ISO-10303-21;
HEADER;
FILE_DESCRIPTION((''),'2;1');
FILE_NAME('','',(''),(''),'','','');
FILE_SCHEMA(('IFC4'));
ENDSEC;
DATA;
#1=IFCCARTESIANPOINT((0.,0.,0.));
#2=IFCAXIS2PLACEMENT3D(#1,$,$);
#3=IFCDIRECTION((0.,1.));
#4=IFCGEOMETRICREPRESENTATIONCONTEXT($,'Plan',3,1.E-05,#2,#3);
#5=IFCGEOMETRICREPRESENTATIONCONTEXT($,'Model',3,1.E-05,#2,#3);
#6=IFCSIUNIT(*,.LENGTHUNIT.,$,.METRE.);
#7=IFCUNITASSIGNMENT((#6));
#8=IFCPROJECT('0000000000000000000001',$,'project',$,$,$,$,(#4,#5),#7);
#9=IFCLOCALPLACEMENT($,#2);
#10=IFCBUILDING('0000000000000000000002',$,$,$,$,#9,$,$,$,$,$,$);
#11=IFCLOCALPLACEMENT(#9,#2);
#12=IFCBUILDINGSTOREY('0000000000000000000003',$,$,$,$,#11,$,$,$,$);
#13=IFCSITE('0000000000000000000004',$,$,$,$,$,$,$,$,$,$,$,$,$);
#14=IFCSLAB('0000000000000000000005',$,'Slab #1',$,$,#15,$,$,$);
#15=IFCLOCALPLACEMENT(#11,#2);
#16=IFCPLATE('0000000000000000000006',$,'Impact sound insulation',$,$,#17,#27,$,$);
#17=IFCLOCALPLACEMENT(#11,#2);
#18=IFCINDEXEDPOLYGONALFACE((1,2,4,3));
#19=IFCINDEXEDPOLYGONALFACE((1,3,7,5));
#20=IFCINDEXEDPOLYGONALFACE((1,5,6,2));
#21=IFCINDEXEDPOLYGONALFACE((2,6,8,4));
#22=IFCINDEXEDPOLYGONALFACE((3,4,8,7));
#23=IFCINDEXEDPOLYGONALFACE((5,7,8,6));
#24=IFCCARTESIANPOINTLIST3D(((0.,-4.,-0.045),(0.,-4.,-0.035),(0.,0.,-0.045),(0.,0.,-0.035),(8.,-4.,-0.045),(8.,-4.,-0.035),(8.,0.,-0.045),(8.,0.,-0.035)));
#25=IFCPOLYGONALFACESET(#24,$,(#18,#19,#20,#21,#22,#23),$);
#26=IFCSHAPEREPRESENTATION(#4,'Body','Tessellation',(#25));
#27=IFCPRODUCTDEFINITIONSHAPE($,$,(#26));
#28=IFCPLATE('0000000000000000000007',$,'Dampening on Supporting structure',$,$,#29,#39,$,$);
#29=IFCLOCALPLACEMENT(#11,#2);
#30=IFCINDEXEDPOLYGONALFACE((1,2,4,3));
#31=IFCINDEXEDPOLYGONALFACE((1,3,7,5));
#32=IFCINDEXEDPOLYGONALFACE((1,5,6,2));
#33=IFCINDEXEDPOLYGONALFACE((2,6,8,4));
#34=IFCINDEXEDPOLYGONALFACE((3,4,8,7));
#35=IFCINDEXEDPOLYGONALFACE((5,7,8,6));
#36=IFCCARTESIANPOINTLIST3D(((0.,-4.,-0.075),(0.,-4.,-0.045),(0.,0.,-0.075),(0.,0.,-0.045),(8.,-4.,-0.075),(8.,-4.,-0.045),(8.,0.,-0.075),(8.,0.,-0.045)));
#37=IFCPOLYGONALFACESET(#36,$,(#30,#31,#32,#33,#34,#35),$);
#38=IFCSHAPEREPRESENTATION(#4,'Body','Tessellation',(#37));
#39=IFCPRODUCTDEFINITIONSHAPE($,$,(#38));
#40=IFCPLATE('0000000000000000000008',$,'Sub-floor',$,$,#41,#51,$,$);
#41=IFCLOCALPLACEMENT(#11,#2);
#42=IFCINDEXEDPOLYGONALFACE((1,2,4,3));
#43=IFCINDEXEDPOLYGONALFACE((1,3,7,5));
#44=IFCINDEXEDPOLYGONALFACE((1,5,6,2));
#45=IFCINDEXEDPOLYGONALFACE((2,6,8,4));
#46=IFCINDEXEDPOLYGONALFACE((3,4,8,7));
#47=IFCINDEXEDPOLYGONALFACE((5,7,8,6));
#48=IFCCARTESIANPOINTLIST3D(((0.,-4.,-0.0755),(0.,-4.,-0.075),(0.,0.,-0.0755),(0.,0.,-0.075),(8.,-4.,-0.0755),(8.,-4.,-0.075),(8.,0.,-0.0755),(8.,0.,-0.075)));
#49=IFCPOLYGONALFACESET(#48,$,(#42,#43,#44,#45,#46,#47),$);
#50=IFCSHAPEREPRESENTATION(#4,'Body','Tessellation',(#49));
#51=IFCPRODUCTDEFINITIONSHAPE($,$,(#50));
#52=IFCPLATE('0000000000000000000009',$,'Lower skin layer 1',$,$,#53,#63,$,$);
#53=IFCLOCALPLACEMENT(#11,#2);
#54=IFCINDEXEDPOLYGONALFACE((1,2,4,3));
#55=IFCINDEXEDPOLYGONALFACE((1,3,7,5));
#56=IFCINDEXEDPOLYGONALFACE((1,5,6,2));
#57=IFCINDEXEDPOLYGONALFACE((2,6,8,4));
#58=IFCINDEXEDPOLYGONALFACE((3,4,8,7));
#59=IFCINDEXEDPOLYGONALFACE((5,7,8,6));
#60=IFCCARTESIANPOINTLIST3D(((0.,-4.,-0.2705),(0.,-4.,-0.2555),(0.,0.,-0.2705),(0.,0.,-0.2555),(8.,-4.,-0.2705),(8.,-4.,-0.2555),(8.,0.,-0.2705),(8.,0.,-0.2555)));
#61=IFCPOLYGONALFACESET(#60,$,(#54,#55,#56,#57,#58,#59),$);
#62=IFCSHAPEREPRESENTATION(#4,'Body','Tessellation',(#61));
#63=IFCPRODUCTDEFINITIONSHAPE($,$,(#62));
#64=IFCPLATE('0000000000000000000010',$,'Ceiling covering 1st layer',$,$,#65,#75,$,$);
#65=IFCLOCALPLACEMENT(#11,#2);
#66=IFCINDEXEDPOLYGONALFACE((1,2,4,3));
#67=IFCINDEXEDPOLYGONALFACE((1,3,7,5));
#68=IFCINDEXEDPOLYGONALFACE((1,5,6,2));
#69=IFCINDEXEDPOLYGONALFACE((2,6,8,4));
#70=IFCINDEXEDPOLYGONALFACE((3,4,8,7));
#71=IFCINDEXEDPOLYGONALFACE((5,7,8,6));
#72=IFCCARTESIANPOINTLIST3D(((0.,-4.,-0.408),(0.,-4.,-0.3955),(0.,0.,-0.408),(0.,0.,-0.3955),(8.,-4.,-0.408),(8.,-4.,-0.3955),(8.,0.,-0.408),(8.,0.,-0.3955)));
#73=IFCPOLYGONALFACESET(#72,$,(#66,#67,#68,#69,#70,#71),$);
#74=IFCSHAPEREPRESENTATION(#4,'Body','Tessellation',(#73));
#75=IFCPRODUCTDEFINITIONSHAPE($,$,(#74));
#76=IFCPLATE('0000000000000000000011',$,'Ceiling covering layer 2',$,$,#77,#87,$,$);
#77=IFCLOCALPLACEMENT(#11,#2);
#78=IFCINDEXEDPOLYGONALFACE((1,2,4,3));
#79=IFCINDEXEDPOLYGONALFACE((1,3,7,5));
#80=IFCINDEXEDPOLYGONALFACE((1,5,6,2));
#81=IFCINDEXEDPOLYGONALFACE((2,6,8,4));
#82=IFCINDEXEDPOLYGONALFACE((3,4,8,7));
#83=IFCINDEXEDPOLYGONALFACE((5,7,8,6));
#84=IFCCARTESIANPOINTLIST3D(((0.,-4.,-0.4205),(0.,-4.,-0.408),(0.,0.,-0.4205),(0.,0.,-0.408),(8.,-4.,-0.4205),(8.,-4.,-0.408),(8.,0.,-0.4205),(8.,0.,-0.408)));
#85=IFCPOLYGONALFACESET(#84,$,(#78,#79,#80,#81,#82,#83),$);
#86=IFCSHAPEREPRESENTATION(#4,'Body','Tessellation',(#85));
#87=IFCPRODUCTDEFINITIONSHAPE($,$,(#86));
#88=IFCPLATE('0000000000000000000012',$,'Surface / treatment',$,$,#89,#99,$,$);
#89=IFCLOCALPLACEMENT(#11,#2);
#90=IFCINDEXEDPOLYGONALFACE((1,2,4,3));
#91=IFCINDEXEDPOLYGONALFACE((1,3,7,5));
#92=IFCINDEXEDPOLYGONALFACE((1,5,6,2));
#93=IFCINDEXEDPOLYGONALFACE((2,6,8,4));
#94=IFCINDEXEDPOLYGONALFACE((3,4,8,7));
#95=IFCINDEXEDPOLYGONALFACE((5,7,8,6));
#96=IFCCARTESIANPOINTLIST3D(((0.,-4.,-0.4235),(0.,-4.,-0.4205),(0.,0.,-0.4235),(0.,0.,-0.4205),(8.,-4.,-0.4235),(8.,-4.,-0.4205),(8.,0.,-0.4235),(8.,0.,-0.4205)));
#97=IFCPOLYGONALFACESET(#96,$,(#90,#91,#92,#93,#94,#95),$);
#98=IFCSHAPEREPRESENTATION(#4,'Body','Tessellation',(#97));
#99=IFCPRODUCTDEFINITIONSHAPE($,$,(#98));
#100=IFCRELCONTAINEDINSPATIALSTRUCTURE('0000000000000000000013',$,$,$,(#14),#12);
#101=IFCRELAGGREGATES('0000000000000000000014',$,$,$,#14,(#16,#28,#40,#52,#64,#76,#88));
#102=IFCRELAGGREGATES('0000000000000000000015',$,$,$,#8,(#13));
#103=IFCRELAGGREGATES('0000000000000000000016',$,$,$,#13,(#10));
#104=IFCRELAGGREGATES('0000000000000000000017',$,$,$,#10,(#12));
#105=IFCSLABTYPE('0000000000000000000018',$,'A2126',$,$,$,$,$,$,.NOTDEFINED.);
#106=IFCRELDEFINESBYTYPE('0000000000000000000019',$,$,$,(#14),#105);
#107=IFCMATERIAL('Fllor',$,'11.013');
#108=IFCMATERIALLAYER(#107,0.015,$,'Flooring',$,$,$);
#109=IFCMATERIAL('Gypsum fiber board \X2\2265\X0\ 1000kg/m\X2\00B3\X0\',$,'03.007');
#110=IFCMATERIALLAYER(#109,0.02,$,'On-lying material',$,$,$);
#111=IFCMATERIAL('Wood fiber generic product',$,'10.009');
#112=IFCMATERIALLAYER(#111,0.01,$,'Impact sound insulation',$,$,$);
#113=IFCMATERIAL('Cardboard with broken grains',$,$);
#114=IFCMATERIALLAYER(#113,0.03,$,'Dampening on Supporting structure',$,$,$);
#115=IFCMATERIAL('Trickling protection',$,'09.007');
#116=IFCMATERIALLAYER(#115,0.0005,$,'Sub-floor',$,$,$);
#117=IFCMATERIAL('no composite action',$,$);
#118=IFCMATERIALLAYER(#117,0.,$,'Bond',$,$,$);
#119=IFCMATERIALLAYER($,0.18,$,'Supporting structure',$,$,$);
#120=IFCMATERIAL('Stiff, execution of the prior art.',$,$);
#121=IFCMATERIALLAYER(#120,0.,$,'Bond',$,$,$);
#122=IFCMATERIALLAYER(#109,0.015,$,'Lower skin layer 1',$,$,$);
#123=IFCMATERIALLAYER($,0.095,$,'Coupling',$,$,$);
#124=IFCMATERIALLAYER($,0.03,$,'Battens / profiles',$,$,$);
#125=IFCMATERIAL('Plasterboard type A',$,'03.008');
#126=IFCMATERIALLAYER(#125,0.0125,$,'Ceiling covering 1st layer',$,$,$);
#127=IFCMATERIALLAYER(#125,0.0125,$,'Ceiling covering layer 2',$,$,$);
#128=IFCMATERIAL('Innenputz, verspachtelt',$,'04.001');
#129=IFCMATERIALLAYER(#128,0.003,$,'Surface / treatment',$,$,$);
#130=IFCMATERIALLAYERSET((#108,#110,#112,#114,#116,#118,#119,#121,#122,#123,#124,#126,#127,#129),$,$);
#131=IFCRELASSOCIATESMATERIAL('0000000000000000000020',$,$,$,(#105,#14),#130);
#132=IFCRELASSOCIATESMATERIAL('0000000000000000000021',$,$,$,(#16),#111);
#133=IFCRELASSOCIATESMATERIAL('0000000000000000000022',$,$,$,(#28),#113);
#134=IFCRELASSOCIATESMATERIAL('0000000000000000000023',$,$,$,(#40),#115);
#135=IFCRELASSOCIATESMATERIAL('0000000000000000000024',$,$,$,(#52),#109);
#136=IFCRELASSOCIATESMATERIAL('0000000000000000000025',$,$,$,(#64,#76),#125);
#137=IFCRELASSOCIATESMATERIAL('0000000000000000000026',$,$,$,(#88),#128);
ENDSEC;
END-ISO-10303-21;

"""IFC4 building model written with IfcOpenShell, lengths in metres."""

from ifc_helpers import new_model, si_unit, direction, frame, frame_2d, origin, place, context, project, spatial, rectangle, extrude, material, layer, layer_set, type_object, element, aggregate, save


model = new_model("IFC4")

# Units and contexts
plan_context = context("Plan", 3, precision=1e-05, world=origin(), true_north=direction((0.0, 1.0)))
model_context = context("Model", 3, precision=1e-05, world=origin(), true_north=direction((0.0, 1.0)))
ifc_project = project(units=[si_unit("LENGTHUNIT", "METRE")], contexts=[plan_context, model_context])

# Site, building, storey
site = spatial("IfcSite", under=ifc_project)
building_placement = place(None, origin())
building = spatial("IfcBuilding", under=site, at=building_placement)
storey_placement = place(building_placement, origin())
storey = spatial("IfcBuildingStorey", under=building, at=storey_placement)

# Slab, plates
ifc_material_1 = material(Name="Fllor", Category="11.013")
ifc_layer_1 = layer(ifc_material_1, 0.015, Name="Flooring")
ifc_material_2 = material(Name="Gypsum fiber board ≥ 1000kg/m³", Category="03.007")
ifc_layer_2 = layer(ifc_material_2, 0.02, Name="On-lying material")
ifc_material_3 = material(Name="Wood fiber generic product", Category="10.009")
ifc_layer_3 = layer(ifc_material_3, 0.01, Name="Impact sound insulation")
ifc_material_4 = material(Name="Cardboard with broken grains")
ifc_layer_4 = layer(ifc_material_4, 0.03, Name="Dampening on Supporting structure")
ifc_material_5 = material(Name="Trickling protection", Category="09.007")
ifc_layer_5 = layer(ifc_material_5, 0.0005, Name="Sub-floor")
ifc_material_6 = material(Name="no composite action")
ifc_layer_6 = layer(ifc_material_6, 0.0, Name="Bond")
ifc_layer_7 = layer(None, 0.18, Name="Supporting structure")
ifc_material_7 = material(Name="Stiff, execution of the prior art.")
ifc_layer_8 = layer(ifc_material_7, 0.0, Name="Bond")
ifc_layer_9 = layer(ifc_material_2, 0.015, Name="Lower skin layer 1")
ifc_layer_10 = layer(None, 0.095, Name="Coupling")
ifc_layer_11 = layer(None, 0.03, Name="Battens / profiles")
ifc_material_8 = material(Name="Plasterboard type A", Category="03.008")
ifc_layer_12 = layer(ifc_material_8, 0.0125, Name="Ceiling covering 1st layer")
ifc_layer_13 = layer(ifc_material_8, 0.0125, Name="Ceiling covering layer 2")
ifc_material_9 = material(Name="Innenputz, verspachtelt", Category="04.001")
ifc_layer_14 = layer(ifc_material_9, 0.003, Name="Surface / treatment")
ifc_layer_set = layer_set([ifc_layer_1, ifc_layer_2, ifc_layer_3, ifc_layer_4, ifc_layer_5, ifc_layer_6, ifc_layer_7, ifc_layer_8, ifc_layer_9, ifc_layer_10, ifc_layer_11, ifc_layer_12, ifc_layer_13, ifc_layer_14])
slab_type = type_object("IfcSlabType", Name="A2126", PredefinedType="NOTDEFINED", material=ifc_layer_set)
slab_placement = place(None, frame((0.0, 0.0, 0.0), z_axis=(0.0, 0.0, -1.0), x_axis=(1.0, 0.0, 0.0)))
slab = element("IfcSlab", 1, at=slab_placement, inside=storey, type_object=slab_type, material=ifc_layer_set, Name="Slab #1")
plate_1_placement = place(slab_placement, origin())
plate_1 = element("IfcPlate", 2, at=plate_1_placement, material=ifc_material_3, Name="Impact sound insulation", context=plan_context, shape_type="SweptSolid", body=[
    extrude(rectangle(XDim=8.0, YDim=4.0, at=frame_2d((4.0, 2.0), x_axis=(1.0, 0.0))), frame((0.0, 0.0, 0.035), z_axis=(0.0, 0.0, 1.0), x_axis=(1.0, 0.0, 0.0)), (0.0, 0.0, 1.0), 0.01),
])
plate_2_placement = place(slab_placement, origin())
plate_2 = element("IfcPlate", 3, at=plate_2_placement, material=ifc_material_4, Name="Dampening on Supporting structure", context=plan_context, shape_type="SweptSolid", body=[
    extrude(rectangle(XDim=8.0, YDim=4.0, at=frame_2d((4.0, 2.0), x_axis=(1.0, 0.0))), frame((0.0, 0.0, 0.045), z_axis=(0.0, 0.0, 1.0), x_axis=(1.0, 0.0, 0.0)), (0.0, 0.0, 1.0), 0.03),
])
plate_3_placement = place(slab_placement, origin())
plate_3 = element("IfcPlate", 4, at=plate_3_placement, material=ifc_material_5, Name="Sub-floor", context=plan_context, shape_type="SweptSolid", body=[
    extrude(rectangle(XDim=8.0, YDim=4.0, at=frame_2d((4.0, 2.0), x_axis=(1.0, 0.0))), frame((0.0, 0.0, 0.075), z_axis=(0.0, 0.0, 1.0), x_axis=(1.0, 0.0, 0.0)), (0.0, 0.0, 1.0), 0.0005),
])
plate_4_placement = place(slab_placement, origin())
plate_4 = element("IfcPlate", 5, at=plate_4_placement, material=ifc_material_2, Name="Lower skin layer 1", context=plan_context, shape_type="SweptSolid", body=[
    extrude(rectangle(XDim=8.0, YDim=4.0, at=frame_2d((4.0, 2.0), x_axis=(1.0, 0.0))), frame((0.0, 0.0, 0.2555), z_axis=(0.0, 0.0, 1.0), x_axis=(1.0, 0.0, 0.0)), (0.0, 0.0, 1.0), 0.015),
])
plate_5_placement = place(slab_placement, origin())
plate_5 = element("IfcPlate", 6, at=plate_5_placement, material=ifc_material_8, Name="Ceiling covering 1st layer", context=plan_context, shape_type="SweptSolid", body=[
    extrude(rectangle(XDim=8.0, YDim=4.0, at=frame_2d((4.0, 2.0), x_axis=(1.0, 0.0))), frame((0.0, 0.0, 0.3955), z_axis=(0.0, 0.0, 1.0), x_axis=(1.0, 0.0, 0.0)), (0.0, 0.0, 1.0), 0.0125),
])
plate_6_placement = place(slab_placement, origin())
plate_6 = element("IfcPlate", 7, at=plate_6_placement, material=ifc_material_8, Name="Ceiling covering layer 2", context=plan_context, shape_type="SweptSolid", body=[
    extrude(rectangle(XDim=8.0, YDim=4.0, at=frame_2d((4.0, 2.0), x_axis=(1.0, 0.0))), frame((0.0, 0.0, 0.408), z_axis=(0.0, 0.0, 1.0), x_axis=(1.0, 0.0, 0.0)), (0.0, 0.0, 1.0), 0.0125),
])
plate_7_placement = place(slab_placement, origin())
plate_7 = element("IfcPlate", 8, at=plate_7_placement, material=ifc_material_9, Name="Surface / treatment", context=plan_context, shape_type="SweptSolid", body=[
    extrude(rectangle(XDim=8.0, YDim=4.0, at=frame_2d((4.0, 2.0), x_axis=(1.0, 0.0))), frame((0.0, 0.0, 0.4205), z_axis=(0.0, 0.0, 1.0), x_axis=(1.0, 0.0, 0.0)), (0.0, 0.0, 1.0), 0.003),
])
aggregate(slab, [plate_1, plate_2, plate_3, plate_4, plate_5, plate_6, plate_7])

save(model, "model.ifc")
